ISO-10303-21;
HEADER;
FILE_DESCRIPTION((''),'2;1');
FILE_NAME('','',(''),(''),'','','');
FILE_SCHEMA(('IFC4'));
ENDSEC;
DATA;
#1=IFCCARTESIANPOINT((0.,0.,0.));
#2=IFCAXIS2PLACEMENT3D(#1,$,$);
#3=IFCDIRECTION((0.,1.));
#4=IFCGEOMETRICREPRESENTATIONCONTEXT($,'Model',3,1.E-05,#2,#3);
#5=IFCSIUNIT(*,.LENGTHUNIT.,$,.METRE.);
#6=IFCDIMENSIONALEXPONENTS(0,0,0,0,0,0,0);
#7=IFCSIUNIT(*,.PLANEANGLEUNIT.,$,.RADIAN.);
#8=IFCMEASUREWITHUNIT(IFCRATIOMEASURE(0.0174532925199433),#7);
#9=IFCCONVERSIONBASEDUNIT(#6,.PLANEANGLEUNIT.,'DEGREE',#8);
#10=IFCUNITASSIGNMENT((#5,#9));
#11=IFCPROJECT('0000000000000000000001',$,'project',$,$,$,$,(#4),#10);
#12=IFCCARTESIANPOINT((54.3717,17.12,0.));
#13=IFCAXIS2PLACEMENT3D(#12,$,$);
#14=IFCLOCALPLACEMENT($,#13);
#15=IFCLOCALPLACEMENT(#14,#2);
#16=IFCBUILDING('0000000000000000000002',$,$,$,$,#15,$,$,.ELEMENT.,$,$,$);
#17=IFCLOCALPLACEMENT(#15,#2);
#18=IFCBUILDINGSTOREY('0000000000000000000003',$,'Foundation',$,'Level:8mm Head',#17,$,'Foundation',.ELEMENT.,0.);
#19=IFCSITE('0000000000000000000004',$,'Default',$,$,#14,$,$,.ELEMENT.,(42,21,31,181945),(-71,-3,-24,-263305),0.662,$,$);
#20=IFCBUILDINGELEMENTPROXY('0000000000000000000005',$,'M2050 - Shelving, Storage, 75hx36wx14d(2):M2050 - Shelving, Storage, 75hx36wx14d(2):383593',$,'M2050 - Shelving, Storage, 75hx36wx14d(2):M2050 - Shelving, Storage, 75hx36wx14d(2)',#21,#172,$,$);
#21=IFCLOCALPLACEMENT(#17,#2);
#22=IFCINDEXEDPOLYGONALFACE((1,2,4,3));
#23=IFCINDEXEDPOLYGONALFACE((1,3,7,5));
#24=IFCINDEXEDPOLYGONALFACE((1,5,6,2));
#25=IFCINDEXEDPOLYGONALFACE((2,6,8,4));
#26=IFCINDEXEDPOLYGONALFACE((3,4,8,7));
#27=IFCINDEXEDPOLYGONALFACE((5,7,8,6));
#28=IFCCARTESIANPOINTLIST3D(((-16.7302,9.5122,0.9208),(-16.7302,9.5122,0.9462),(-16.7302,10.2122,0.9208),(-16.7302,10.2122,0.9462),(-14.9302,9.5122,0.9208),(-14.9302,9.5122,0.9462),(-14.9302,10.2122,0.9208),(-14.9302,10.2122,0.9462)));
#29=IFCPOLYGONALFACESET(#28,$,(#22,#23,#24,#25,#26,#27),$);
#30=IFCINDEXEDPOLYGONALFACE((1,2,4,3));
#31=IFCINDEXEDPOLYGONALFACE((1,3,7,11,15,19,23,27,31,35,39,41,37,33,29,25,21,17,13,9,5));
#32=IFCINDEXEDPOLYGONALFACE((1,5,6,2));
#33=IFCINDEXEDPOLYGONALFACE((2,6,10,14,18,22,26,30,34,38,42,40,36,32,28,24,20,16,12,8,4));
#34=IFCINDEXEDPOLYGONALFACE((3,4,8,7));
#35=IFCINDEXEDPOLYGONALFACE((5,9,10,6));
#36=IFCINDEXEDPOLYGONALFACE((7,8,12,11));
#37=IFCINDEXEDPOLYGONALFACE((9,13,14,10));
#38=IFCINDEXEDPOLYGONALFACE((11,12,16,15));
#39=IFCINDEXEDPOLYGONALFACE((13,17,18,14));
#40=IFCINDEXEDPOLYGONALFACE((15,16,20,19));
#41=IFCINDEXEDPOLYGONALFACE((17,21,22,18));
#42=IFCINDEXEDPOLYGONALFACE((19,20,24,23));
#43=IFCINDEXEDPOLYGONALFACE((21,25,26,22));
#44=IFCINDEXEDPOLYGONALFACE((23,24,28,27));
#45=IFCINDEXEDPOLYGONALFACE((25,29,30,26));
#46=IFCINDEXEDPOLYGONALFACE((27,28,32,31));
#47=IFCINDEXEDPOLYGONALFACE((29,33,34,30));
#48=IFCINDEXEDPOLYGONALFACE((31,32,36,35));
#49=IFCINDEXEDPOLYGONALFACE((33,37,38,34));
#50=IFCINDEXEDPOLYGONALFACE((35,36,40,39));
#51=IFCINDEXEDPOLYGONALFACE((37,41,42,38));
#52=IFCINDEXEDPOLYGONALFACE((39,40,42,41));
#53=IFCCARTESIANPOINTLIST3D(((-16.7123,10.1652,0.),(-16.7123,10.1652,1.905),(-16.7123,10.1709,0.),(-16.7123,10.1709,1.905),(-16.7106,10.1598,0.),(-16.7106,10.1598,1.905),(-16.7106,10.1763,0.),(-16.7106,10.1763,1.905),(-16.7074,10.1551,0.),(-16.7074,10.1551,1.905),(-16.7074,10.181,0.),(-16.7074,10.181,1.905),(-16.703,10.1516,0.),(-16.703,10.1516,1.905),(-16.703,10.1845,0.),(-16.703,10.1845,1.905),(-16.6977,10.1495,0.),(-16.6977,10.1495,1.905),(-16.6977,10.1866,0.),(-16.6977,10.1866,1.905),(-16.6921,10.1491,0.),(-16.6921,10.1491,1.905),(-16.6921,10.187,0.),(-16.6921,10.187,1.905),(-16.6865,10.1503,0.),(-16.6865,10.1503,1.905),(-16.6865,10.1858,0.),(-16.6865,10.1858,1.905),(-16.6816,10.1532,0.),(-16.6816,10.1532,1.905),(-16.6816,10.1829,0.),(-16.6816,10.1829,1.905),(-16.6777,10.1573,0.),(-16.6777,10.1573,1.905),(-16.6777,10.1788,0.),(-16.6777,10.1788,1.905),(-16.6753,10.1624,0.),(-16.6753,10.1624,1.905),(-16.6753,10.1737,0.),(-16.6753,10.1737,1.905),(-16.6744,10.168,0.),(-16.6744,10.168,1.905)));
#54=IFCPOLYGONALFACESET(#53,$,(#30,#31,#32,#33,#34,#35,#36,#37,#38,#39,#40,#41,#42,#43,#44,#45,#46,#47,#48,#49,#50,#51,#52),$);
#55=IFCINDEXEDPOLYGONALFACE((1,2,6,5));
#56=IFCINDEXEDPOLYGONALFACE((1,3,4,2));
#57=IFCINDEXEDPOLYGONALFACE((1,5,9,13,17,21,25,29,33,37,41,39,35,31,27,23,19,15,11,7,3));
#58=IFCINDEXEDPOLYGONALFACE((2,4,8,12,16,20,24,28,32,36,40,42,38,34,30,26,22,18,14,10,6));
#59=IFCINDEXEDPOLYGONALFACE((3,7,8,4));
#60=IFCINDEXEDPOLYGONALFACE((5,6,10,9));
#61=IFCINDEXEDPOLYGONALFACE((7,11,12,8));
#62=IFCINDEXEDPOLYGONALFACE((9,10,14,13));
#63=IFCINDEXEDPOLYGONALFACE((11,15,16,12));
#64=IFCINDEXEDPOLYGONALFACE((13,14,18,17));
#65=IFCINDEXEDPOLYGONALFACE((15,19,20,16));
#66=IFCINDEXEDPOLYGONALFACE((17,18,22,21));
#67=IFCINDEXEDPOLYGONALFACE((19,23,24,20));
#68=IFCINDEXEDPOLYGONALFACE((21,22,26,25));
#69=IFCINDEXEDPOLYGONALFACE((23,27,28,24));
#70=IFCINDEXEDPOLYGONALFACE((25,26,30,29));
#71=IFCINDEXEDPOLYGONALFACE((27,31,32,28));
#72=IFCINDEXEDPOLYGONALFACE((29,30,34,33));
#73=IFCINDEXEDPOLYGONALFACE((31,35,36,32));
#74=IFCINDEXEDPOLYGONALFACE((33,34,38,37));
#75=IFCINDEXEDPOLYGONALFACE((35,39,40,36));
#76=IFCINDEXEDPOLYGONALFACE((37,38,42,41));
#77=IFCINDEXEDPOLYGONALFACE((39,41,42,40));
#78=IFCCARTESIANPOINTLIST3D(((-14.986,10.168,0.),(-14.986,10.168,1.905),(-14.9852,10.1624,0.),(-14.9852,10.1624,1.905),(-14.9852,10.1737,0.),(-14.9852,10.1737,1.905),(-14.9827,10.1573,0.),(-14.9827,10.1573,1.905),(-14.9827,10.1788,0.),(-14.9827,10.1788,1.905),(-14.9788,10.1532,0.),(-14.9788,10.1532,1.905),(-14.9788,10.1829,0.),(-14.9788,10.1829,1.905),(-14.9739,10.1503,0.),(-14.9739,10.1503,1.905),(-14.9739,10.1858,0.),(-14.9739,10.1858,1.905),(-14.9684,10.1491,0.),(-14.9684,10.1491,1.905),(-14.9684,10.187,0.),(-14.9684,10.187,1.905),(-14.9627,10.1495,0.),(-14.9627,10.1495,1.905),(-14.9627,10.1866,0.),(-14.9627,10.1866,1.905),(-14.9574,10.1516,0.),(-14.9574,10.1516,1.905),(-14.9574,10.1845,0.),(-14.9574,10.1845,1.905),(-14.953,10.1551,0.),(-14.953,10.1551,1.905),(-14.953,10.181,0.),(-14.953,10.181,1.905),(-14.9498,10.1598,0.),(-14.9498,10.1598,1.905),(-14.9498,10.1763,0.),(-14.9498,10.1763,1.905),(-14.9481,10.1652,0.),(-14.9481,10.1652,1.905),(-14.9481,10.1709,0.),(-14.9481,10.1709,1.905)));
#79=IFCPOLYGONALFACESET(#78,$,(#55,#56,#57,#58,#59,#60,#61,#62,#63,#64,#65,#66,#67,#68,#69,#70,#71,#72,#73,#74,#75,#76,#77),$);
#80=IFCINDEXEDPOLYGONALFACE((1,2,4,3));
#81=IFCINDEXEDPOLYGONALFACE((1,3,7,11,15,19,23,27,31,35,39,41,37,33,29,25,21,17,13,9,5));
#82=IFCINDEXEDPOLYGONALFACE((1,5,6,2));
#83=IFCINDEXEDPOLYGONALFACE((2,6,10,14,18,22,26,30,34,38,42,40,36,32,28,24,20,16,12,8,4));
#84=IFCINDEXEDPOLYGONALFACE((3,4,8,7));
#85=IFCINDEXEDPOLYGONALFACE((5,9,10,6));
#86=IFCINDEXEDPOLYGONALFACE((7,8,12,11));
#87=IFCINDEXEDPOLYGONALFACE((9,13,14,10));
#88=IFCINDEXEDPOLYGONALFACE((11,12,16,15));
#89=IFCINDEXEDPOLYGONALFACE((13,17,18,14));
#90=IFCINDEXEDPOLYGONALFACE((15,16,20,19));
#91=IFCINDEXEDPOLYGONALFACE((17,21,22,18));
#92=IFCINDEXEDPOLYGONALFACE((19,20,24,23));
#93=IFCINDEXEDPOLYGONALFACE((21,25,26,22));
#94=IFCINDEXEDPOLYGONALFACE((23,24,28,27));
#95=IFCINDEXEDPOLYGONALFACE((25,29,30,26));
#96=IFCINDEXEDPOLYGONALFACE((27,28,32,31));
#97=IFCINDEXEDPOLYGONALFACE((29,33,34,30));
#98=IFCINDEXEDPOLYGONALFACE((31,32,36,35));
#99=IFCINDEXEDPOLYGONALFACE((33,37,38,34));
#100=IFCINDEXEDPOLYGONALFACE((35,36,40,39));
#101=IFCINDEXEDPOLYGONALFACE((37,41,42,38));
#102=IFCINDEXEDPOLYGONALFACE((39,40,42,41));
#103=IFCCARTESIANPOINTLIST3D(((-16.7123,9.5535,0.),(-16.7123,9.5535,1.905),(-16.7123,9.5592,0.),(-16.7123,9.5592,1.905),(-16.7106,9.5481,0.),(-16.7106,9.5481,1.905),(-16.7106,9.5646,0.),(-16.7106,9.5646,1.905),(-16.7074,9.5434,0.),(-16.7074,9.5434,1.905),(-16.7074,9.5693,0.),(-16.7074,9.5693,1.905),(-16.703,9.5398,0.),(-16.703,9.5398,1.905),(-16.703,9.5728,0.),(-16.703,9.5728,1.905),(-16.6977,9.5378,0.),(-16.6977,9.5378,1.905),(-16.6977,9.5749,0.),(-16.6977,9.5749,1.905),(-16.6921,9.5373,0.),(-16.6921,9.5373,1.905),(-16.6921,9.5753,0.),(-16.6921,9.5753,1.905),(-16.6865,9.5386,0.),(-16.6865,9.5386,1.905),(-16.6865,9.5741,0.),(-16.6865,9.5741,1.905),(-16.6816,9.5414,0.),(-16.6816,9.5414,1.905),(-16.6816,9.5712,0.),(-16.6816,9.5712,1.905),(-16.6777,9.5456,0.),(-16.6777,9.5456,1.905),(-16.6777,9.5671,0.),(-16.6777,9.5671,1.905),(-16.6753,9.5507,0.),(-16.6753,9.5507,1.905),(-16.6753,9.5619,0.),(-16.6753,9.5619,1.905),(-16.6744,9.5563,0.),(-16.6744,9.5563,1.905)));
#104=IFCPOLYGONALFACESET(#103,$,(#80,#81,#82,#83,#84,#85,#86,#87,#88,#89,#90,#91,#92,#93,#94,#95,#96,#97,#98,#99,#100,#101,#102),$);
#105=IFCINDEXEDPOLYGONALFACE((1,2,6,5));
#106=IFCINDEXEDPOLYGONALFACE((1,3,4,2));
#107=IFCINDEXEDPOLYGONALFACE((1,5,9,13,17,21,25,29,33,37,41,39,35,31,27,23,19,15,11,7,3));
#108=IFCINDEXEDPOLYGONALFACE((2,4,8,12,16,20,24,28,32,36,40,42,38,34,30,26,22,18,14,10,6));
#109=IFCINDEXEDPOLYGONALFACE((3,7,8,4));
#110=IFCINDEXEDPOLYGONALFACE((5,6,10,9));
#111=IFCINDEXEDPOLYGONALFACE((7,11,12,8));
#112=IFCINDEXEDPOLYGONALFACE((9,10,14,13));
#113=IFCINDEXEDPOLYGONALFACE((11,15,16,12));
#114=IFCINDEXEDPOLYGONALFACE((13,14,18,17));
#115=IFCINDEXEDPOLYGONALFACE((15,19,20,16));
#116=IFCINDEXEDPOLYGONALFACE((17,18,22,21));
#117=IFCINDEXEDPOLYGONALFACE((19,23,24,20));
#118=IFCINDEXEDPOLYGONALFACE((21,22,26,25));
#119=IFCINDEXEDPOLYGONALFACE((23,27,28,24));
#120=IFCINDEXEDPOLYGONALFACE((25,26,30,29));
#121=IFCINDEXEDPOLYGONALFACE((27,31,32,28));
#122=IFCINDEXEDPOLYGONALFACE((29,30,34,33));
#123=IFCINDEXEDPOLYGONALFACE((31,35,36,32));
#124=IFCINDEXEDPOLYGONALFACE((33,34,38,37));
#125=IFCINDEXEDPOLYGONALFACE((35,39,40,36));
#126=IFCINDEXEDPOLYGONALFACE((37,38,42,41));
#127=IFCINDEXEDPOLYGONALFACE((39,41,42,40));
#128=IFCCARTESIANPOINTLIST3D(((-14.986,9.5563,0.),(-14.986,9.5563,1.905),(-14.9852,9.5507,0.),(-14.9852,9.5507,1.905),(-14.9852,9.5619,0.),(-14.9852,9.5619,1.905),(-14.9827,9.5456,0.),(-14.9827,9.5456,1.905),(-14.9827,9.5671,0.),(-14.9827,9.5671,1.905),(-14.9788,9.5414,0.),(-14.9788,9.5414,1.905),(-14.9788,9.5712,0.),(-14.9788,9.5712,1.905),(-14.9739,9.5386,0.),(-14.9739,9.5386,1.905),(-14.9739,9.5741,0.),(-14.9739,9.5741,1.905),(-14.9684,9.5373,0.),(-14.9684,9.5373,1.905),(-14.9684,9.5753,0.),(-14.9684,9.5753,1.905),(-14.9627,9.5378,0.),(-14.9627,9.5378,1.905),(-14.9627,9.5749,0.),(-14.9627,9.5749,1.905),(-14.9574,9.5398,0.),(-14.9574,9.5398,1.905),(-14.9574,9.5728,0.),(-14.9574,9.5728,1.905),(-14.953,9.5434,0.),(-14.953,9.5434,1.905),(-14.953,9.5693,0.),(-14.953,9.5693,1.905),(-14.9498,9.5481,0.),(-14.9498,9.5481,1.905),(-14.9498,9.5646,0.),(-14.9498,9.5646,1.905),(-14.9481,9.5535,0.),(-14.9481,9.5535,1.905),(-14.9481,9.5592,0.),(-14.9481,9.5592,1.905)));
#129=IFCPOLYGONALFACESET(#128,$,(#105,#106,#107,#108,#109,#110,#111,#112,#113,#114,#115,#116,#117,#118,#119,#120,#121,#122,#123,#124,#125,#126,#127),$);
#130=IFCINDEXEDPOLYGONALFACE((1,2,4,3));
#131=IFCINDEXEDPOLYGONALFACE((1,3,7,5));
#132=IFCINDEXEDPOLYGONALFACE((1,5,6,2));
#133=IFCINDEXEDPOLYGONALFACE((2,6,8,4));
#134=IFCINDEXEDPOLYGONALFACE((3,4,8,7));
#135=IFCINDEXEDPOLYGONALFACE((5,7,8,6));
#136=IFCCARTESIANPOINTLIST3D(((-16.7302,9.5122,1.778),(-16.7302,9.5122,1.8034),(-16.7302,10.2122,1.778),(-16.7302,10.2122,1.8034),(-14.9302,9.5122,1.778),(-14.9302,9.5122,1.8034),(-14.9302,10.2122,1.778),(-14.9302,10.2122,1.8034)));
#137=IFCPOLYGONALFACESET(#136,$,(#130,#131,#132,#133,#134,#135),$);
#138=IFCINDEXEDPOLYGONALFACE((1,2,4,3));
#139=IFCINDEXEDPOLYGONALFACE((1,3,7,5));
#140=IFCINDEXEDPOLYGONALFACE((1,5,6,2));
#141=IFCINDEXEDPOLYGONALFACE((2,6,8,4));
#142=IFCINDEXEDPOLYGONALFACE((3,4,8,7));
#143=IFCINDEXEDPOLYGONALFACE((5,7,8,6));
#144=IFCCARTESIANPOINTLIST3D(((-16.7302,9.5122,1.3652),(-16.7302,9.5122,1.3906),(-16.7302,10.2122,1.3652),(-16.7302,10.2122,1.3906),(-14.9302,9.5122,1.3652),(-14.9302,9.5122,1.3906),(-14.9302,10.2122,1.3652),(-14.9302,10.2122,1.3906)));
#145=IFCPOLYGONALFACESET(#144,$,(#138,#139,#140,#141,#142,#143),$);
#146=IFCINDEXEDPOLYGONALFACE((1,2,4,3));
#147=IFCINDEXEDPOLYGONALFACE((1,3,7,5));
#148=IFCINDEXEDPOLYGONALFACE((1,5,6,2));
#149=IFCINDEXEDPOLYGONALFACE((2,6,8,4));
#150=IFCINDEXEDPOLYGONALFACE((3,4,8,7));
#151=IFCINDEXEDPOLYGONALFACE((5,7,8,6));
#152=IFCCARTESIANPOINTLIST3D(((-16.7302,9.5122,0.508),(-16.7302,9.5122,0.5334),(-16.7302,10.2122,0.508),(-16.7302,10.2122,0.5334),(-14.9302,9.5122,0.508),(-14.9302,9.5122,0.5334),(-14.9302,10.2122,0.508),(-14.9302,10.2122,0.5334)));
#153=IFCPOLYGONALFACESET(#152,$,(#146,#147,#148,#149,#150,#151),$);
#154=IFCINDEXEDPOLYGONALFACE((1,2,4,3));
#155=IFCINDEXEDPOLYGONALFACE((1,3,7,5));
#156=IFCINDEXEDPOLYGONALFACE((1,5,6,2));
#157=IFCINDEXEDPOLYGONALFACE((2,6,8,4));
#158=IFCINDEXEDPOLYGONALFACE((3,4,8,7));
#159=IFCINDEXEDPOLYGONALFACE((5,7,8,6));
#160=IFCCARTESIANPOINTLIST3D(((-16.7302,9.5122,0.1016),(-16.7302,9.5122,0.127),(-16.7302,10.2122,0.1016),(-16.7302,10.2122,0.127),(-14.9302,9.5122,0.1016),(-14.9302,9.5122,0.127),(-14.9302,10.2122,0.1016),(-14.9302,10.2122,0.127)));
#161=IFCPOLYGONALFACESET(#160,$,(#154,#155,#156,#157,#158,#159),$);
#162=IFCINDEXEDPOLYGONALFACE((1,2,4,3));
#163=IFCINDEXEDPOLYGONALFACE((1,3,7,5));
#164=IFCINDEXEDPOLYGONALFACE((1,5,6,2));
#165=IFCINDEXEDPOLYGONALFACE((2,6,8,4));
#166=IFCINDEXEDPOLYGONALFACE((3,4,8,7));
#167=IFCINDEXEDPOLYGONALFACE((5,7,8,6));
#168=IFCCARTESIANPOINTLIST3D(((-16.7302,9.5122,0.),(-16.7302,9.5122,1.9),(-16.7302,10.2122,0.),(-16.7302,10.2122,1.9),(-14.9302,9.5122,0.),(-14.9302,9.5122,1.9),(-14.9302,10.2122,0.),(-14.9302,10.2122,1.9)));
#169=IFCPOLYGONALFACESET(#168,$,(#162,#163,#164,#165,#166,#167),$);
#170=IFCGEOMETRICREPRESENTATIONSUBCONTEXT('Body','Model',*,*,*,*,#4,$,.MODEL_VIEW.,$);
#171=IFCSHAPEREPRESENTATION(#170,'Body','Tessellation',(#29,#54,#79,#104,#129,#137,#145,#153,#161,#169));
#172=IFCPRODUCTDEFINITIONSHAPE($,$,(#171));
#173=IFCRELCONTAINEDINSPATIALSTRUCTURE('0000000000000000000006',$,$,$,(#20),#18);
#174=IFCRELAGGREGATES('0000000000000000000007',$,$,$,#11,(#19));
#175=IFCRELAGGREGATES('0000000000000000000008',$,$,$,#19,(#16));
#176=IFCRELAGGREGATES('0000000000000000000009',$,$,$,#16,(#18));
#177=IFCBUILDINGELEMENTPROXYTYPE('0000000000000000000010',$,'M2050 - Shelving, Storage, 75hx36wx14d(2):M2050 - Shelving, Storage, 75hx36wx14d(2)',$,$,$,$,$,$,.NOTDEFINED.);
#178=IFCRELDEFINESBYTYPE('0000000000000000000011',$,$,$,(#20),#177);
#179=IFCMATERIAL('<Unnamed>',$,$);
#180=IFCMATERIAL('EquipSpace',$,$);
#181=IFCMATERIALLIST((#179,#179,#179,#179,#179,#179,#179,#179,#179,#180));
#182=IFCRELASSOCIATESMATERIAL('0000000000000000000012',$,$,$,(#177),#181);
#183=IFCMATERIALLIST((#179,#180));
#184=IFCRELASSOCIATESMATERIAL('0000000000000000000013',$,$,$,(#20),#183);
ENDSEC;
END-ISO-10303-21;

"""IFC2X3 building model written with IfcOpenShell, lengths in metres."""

from ifc_helpers import new_model, entity, si_unit, converted_unit, direction, frame, frame_2d, origin, origin_2d_with_axis, place, context, subcontext, project, spatial, rectangle, circle, extrude, source, transform, mapped, material, material_list, type_object, type_shapes, element, save


model = new_model("IFC2X3")

# Units and contexts
model_context = context("Model", 3, precision=1e-05, world=origin(), true_north=direction((0.0, 1.0)))
body_context = subcontext(model_context, "Body", "Model", "MODEL_VIEW")
ifc_project = project(units=[si_unit("LENGTHUNIT", "METRE"), converted_unit("PLANEANGLEUNIT", "DEGREE", entity("IfcRatioMeasure", 0.0174532925199433), si_unit("PLANEANGLEUNIT", "RADIAN"), dimensions=[0, 0, 0, 0, 0, 0, 0])], contexts=[model_context])

# Site, building, storey
site_placement = place(None, frame((54.3717, 17.12, 0.0)))
site = spatial("IfcSite", under=ifc_project, at=site_placement, Name="Default", CompositionType="ELEMENT", RefLatitude=(42, 21, 31, 181945), RefLongitude=(-71, -3, -24, -263305), RefElevation=0.662)
building_placement = place(site_placement, origin())
building = spatial("IfcBuilding", under=site, at=building_placement, CompositionType="ELEMENT")
storey_placement = place(building_placement, origin())
storey = spatial("IfcBuildingStorey", under=building, at=storey_placement, Name="Foundation", ObjectType="Level:8mm Head", LongName="Foundation", CompositionType="ELEMENT", Elevation=0.0)

# Building element proxy
ifc_material_1 = material(Name="<Unnamed>")
ifc_material_2 = material(Name="EquipSpace")
ifc_material_list_1 = material_list([ifc_material_1, ifc_material_1, ifc_material_1, ifc_material_1, ifc_material_1, ifc_material_1, ifc_material_1, ifc_material_1, ifc_material_1, ifc_material_2])
building_element_proxy_type = type_object("IfcBuildingElementProxyType", Name="M2050 - Shelving, Storage, 75hx36wx14d(2):M2050 - Shelving, Storage, 75hx36wx14d(2)", PredefinedType="NOTDEFINED", material=ifc_material_list_1)
shared_shape = source(origin(), body_context, "Body", "SweptSolid", [
    extrude(rectangle(XDim=1.8, YDim=0.7, at=origin_2d_with_axis()), frame((0.0, 0.0, 0.9207), z_axis=(0.0, 0.0, 1.0), x_axis=(-1.0, 0.0, 0.0)), (0.0, 0.0, 1.0), 0.0254),
    extrude(circle(Radius=0.0191, at=origin_2d_with_axis()), frame((0.8633, -0.3059, 0.0), z_axis=(0.0, 0.0, 1.0), x_axis=(-1.0, 0.0, 0.0)), (0.0, 0.0, 1.0), 1.905),
    extrude(circle(Radius=0.0191, at=origin_2d_with_axis()), frame((-0.8633, -0.3059, 0.0)), (0.0, 0.0, 1.0), 1.905),
    extrude(circle(Radius=0.0191, at=origin_2d_with_axis()), frame((0.8633, 0.3059, 0.0), z_axis=(0.0, 0.0, 1.0), x_axis=(-1.0, 0.0, 0.0)), (0.0, 0.0, 1.0), 1.905),
    extrude(circle(Radius=0.0191, at=origin_2d_with_axis()), frame((-0.8633, 0.3059, 0.0)), (0.0, 0.0, 1.0), 1.905),
    extrude(rectangle(XDim=1.8, YDim=0.7, at=origin_2d_with_axis()), frame((0.0, 0.0, 1.778), z_axis=(0.0, 0.0, 1.0), x_axis=(-1.0, 0.0, 0.0)), (0.0, 0.0, 1.0), 0.0254),
    extrude(rectangle(XDim=1.8, YDim=0.7, at=origin_2d_with_axis()), frame((0.0, 0.0, 1.3653), z_axis=(0.0, 0.0, 1.0), x_axis=(-1.0, 0.0, 0.0)), (0.0, 0.0, 1.0), 0.0254),
    extrude(rectangle(XDim=1.8, YDim=0.7, at=origin_2d_with_axis()), frame((0.0, 0.0, 0.508), z_axis=(0.0, 0.0, 1.0), x_axis=(-1.0, 0.0, 0.0)), (0.0, 0.0, 1.0), 0.0254),
    extrude(rectangle(XDim=1.8, YDim=0.7, at=origin_2d_with_axis()), frame((0.0, 0.0, 0.1016), z_axis=(0.0, 0.0, 1.0), x_axis=(-1.0, 0.0, 0.0)), (0.0, 0.0, 1.0), 0.0254),
    extrude(rectangle(XDim=0.7, YDim=1.8, at=frame_2d((0.0, 0.18), x_axis=(1.0, 0.0))), frame((-0.18, 0.0, 0.0), z_axis=(0.0, 0.0, 1.0), x_axis=(0.0, -1.0, 0.0)), (0.0, 0.0, 1.0), 1.9),
])
type_shapes(building_element_proxy_type, [shared_shape])
ifc_material_list_2 = material_list([ifc_material_1, ifc_material_2])
proxy_1_placement = place(storey_placement, frame((-15.8302, 9.8622, 0.0), z_axis=(0.0, 0.0, 1.0), x_axis=(-1.0, 0.0, 0.0)))
element("IfcBuildingElementProxy", 1, at=proxy_1_placement, inside=storey, type_object=building_element_proxy_type, material=ifc_material_list_2, Name="M2050 - Shelving, Storage, 75hx36wx14d(2):M2050 - Shelving, Storage, 75hx36wx14d(2):383593", ObjectType="M2050 - Shelving, Storage, 75hx36wx14d(2):M2050 - Shelving, Storage, 75hx36wx14d(2)", context=body_context, shape_type="MappedRepresentation", body=[
    mapped(shared_shape, transform((0.0, 0.0, 0.0), scale=1.0)),
])

save(model, "model.ifc")
